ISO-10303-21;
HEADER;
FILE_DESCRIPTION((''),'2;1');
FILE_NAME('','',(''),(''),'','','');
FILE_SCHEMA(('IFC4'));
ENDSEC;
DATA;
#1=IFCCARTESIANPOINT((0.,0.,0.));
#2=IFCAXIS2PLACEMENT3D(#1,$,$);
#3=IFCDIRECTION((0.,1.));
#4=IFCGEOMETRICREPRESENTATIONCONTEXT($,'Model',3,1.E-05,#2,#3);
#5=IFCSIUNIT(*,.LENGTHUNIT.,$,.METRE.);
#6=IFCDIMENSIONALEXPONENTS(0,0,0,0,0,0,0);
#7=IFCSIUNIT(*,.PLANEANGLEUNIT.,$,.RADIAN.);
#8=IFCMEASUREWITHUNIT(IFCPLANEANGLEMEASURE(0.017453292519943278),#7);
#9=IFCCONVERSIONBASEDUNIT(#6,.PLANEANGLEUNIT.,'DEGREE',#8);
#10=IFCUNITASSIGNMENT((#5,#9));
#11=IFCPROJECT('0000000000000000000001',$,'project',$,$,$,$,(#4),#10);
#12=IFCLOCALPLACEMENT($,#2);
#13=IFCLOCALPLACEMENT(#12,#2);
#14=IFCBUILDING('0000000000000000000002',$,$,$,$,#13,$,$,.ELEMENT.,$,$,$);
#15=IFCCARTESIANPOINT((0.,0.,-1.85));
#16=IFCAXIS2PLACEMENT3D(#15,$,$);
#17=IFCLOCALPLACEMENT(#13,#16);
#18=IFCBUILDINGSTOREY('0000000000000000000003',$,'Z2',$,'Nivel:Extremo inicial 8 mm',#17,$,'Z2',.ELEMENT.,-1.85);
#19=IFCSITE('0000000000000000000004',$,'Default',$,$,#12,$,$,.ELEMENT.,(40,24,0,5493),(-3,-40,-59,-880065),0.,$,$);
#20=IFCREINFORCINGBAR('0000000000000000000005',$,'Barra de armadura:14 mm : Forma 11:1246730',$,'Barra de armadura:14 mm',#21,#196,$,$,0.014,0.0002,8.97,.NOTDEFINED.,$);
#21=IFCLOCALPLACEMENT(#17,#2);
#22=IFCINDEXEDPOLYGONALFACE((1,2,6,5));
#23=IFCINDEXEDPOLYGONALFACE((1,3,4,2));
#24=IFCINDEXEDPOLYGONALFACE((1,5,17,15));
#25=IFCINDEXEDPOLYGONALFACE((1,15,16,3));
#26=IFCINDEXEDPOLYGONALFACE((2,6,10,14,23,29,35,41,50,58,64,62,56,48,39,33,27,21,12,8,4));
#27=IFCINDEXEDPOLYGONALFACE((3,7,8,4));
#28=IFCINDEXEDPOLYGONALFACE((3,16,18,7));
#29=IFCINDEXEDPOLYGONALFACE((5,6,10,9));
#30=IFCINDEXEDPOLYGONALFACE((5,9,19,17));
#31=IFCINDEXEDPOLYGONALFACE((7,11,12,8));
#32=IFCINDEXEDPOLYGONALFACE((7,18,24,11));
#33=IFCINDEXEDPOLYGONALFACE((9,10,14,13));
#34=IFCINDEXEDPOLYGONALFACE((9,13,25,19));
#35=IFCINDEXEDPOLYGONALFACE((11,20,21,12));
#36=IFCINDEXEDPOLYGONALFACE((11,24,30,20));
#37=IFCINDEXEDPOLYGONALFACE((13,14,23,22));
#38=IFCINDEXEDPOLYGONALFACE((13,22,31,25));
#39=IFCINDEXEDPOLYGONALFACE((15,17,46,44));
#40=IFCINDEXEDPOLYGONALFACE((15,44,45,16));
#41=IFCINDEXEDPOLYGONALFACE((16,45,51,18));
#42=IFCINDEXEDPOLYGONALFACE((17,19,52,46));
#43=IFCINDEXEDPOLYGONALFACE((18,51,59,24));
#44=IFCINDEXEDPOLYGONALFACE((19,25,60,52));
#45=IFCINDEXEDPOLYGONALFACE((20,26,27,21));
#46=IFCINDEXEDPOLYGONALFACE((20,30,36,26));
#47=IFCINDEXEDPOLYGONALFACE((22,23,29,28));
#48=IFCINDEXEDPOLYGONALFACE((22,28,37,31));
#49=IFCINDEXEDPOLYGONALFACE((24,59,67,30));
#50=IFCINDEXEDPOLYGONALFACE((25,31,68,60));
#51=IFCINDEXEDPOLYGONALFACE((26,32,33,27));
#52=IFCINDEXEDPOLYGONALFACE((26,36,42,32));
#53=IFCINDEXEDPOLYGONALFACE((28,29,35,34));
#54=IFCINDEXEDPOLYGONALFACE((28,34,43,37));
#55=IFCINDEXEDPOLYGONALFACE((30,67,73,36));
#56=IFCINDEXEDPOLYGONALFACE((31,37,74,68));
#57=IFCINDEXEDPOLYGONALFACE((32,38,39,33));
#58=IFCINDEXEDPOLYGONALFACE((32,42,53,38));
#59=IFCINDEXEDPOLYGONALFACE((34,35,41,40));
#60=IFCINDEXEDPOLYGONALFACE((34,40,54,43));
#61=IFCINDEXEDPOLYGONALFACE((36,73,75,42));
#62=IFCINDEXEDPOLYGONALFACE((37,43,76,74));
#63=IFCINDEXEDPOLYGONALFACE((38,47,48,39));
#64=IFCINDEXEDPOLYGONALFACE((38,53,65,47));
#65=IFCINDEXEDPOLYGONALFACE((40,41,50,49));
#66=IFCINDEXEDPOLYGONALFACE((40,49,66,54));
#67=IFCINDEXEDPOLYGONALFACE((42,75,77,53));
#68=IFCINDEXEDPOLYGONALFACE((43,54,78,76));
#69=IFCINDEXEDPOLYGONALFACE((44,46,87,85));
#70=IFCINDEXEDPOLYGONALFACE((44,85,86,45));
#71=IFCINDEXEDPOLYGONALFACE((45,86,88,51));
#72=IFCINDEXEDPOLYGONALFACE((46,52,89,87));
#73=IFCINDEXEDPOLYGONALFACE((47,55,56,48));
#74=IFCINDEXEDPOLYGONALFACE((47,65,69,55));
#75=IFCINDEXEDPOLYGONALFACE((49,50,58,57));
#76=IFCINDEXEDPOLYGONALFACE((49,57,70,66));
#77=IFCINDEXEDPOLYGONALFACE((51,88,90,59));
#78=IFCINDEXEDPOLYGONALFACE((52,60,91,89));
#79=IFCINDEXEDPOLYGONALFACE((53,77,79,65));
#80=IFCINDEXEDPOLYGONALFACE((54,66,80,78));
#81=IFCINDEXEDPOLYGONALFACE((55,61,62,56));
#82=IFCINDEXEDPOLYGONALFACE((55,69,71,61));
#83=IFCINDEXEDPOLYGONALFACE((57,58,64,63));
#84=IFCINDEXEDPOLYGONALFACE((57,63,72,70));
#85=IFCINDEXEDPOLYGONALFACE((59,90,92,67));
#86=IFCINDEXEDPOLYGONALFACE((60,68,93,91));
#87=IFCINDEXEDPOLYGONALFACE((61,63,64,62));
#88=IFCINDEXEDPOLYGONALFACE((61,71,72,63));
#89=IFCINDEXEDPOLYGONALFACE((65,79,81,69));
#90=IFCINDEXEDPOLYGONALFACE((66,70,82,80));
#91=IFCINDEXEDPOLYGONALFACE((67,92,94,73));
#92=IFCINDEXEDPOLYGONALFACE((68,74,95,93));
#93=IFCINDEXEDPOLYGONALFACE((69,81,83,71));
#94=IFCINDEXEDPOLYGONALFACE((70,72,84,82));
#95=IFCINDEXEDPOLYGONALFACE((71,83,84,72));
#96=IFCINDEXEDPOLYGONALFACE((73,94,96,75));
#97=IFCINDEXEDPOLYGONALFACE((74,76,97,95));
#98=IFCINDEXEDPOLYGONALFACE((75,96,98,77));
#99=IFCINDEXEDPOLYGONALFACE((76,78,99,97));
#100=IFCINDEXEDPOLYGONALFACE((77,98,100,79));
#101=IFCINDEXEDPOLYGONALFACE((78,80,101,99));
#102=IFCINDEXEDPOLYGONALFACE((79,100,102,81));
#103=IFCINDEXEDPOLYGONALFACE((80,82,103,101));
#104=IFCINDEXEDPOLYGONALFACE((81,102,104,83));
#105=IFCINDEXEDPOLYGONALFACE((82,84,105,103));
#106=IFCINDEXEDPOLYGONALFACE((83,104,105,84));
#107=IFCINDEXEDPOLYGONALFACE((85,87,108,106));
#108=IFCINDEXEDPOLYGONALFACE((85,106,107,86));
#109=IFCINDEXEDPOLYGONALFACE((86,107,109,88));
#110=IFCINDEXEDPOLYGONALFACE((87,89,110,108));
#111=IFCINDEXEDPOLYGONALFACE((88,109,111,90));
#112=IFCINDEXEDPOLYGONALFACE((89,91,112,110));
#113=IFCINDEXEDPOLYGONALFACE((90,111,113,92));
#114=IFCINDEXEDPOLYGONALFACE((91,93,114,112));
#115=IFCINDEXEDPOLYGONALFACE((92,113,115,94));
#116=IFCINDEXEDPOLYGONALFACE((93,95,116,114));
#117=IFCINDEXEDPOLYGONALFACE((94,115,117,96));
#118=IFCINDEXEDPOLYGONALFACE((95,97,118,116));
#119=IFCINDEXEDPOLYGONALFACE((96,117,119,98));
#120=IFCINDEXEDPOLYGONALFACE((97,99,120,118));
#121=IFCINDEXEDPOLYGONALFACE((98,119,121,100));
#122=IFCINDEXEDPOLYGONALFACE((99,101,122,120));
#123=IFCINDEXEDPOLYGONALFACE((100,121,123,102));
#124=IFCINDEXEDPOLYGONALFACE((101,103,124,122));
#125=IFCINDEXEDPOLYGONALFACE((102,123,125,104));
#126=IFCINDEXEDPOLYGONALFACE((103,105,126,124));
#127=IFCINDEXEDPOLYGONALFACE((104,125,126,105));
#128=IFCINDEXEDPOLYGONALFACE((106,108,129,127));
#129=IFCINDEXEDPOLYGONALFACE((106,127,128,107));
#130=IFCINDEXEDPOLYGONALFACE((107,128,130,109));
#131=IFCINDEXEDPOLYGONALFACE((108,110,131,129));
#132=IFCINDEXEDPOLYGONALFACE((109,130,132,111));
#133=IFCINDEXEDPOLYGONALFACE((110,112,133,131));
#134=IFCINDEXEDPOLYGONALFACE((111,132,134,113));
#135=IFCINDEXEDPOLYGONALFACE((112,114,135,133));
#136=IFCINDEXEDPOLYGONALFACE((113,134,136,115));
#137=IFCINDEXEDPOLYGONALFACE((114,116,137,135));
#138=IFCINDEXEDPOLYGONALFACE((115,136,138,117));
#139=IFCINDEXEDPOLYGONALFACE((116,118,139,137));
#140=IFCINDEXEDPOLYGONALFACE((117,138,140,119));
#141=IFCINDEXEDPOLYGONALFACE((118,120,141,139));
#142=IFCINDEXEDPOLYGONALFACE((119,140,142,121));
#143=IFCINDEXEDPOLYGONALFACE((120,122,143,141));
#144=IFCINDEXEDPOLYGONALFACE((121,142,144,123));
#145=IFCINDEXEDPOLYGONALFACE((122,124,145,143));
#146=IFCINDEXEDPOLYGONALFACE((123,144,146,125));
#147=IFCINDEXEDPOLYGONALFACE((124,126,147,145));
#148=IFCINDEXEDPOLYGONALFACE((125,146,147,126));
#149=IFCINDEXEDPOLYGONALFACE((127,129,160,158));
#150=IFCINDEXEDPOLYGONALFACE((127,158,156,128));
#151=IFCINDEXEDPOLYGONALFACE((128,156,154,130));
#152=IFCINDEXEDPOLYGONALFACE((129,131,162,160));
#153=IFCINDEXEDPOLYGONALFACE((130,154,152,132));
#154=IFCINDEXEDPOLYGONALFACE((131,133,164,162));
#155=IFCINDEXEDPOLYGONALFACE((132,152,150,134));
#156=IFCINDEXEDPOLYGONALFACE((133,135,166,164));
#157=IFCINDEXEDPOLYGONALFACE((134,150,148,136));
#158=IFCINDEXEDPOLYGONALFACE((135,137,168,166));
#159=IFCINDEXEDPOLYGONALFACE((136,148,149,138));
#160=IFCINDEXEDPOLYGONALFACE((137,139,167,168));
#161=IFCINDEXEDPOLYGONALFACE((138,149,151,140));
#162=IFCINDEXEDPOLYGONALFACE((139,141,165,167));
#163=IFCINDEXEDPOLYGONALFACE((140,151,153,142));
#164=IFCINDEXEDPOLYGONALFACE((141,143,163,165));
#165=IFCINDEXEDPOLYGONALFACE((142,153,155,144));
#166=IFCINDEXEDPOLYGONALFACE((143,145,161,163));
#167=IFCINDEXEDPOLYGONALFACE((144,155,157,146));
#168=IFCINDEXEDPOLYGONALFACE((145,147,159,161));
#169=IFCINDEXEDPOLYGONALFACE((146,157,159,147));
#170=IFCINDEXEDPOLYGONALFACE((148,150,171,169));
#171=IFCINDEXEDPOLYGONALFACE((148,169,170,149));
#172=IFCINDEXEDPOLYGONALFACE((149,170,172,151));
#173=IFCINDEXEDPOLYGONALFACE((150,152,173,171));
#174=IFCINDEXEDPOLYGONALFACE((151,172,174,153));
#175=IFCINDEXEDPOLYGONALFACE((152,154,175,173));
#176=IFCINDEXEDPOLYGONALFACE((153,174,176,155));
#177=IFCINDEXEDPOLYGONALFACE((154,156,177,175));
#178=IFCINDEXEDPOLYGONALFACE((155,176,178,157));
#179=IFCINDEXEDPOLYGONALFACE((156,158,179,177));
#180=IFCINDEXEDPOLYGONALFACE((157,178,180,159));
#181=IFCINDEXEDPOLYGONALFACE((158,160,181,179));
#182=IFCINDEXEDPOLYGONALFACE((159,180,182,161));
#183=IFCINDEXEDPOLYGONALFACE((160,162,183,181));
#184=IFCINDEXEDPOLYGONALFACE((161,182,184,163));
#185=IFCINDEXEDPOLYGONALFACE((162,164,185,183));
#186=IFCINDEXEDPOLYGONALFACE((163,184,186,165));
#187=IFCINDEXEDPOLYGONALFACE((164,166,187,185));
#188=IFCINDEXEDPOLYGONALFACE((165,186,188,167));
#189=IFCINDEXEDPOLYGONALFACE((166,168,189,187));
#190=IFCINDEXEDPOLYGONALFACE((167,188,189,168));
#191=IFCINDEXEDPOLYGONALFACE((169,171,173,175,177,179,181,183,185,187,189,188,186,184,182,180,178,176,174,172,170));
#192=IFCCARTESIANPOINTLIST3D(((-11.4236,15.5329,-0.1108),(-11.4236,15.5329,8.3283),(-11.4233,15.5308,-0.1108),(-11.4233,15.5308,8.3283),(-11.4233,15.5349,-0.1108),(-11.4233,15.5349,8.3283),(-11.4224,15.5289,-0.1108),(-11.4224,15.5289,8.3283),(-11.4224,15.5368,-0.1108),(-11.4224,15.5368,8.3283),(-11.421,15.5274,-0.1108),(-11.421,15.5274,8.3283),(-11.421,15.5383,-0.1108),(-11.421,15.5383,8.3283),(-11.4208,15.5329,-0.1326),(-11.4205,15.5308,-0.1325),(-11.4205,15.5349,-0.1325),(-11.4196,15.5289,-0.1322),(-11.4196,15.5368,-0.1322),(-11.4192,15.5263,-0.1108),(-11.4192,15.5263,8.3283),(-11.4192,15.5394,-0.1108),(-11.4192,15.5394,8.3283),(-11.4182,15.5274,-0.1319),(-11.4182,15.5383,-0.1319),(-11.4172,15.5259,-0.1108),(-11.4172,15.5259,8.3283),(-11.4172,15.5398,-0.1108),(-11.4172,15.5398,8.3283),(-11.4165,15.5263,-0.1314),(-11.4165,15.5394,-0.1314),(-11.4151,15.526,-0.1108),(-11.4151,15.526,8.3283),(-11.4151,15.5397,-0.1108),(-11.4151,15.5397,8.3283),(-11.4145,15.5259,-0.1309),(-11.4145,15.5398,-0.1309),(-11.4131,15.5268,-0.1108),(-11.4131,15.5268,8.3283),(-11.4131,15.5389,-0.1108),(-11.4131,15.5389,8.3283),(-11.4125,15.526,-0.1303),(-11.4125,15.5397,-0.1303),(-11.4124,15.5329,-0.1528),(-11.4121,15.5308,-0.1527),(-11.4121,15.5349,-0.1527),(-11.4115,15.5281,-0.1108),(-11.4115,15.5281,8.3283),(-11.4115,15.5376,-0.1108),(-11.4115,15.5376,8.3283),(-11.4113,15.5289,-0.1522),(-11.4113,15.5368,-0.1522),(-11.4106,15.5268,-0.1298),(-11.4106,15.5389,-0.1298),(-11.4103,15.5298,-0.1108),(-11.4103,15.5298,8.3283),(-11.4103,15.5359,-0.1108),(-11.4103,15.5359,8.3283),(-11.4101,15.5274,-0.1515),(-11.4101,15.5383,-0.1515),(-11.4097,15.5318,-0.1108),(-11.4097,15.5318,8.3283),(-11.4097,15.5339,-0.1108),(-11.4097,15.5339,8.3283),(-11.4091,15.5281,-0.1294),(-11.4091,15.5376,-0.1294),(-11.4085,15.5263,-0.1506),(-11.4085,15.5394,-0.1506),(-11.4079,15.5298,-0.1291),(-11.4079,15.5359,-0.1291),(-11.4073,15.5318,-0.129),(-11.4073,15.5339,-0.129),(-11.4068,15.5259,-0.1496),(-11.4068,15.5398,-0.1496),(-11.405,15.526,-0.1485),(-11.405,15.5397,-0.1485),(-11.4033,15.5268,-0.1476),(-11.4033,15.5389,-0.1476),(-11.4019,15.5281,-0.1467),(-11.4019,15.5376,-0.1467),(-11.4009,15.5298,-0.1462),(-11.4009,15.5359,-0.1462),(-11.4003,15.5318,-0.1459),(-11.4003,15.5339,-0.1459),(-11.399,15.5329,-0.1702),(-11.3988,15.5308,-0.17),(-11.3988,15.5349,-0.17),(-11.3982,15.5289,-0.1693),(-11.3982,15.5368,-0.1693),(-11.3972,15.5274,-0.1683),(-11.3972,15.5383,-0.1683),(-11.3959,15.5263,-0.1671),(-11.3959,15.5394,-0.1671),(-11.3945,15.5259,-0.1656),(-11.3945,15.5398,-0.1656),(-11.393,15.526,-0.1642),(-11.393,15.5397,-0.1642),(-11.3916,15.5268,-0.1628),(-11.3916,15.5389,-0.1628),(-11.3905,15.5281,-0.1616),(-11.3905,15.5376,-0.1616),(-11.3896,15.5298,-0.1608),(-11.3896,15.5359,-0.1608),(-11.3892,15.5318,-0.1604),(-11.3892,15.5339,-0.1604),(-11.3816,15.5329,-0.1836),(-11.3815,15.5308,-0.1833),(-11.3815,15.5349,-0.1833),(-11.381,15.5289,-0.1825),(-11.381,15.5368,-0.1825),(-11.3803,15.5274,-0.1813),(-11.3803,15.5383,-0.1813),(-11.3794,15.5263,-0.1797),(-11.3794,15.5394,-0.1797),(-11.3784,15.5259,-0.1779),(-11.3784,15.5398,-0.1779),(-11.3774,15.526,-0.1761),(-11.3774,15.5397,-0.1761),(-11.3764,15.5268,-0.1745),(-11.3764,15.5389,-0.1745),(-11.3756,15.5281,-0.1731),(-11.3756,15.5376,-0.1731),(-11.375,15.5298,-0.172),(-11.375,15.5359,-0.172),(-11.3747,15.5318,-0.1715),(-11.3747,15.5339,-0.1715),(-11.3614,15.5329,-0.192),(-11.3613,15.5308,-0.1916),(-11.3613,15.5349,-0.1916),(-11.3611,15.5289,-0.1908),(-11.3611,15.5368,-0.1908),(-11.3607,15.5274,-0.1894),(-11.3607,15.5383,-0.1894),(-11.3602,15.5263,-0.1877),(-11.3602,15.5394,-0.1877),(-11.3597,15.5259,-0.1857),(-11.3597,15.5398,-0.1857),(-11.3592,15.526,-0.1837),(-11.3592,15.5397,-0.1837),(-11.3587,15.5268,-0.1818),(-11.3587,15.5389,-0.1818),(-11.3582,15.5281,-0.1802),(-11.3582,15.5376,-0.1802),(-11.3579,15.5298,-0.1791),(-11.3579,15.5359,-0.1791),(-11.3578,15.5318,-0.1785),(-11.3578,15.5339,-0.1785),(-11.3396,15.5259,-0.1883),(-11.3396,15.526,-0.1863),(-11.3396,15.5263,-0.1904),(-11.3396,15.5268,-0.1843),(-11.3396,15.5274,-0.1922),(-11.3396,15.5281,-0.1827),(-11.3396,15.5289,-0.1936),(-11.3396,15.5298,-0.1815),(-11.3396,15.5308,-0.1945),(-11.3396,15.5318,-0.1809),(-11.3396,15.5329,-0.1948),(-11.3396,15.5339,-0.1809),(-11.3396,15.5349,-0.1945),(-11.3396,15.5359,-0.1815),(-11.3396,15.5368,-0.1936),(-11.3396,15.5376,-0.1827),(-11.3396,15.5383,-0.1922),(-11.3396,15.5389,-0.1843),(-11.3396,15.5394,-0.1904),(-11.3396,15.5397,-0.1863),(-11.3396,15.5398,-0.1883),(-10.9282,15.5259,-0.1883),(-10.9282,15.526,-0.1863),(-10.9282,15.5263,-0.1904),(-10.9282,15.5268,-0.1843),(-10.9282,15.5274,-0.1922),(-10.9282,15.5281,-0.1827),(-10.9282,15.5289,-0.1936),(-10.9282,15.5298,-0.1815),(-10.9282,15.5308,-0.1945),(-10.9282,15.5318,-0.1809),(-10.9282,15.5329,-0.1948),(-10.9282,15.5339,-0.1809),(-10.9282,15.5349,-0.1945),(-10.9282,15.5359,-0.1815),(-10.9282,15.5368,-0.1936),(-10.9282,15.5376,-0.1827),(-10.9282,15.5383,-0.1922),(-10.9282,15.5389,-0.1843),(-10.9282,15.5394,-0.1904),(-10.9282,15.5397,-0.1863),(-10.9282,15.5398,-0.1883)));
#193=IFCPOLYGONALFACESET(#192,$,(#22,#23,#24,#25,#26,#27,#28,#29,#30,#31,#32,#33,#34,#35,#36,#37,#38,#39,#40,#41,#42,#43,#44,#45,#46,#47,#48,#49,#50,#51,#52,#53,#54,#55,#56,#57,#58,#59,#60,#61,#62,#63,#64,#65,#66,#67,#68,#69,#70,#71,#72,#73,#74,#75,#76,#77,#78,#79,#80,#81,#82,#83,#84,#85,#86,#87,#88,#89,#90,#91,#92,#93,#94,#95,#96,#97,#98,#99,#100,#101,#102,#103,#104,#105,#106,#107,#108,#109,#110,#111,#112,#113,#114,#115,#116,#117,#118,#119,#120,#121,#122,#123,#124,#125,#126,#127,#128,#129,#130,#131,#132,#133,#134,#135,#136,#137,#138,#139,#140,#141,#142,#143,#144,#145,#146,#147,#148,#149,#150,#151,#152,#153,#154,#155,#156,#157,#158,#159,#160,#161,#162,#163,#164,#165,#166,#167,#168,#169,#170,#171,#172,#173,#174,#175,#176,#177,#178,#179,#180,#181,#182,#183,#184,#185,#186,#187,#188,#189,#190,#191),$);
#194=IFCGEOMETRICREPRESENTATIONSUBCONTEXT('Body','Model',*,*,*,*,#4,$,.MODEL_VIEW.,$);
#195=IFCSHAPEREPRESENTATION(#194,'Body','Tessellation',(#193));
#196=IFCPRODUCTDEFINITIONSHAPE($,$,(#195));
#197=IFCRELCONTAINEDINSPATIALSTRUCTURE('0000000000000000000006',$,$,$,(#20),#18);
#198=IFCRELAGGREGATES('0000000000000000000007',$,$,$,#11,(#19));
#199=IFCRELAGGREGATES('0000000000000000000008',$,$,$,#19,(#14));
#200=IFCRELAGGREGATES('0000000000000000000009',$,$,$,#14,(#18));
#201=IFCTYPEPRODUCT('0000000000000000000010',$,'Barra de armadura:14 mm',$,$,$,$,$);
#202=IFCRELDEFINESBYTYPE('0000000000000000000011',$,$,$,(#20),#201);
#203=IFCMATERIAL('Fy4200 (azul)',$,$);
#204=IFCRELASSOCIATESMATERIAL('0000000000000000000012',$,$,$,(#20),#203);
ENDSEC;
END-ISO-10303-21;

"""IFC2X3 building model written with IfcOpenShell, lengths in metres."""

from ifc_helpers import new_model, entity, si_unit, converted_unit, direction, frame, origin, place, context, subcontext, project, spatial, material, type_object, element, save


model = new_model("IFC2X3")

# Units and contexts
model_context = context("Model", 3, precision=1e-05, world=origin(), true_north=direction((0.0, 1.0)))
body_context = subcontext(model_context, "Body", "Model", "MODEL_VIEW")
ifc_project = project(units=[si_unit("LENGTHUNIT", "METRE"), converted_unit("PLANEANGLEUNIT", "DEGREE", entity("IfcPlaneAngleMeasure", 0.017453292519943278), si_unit("PLANEANGLEUNIT", "RADIAN"), dimensions=[0, 0, 0, 0, 0, 0, 0])], contexts=[model_context])

# Site, building, storey
site_placement = place(None, origin())
site = spatial("IfcSite", under=ifc_project, at=site_placement, Name="Default", CompositionType="ELEMENT", RefLatitude=(40, 24, 0, 5493), RefLongitude=(-3, -40, -59, -880065), RefElevation=0.0)
building_placement = place(site_placement, origin())
building = spatial("IfcBuilding", under=site, at=building_placement, CompositionType="ELEMENT")
storey_placement = place(building_placement, frame((0.0, 0.0, -1.85)))
storey = spatial("IfcBuildingStorey", under=building, at=storey_placement, Name="Z2", ObjectType="Nivel:Extremo inicial 8 mm", LongName="Z2", CompositionType="ELEMENT", Elevation=-1.85)

# Reinforcing bar
ifc_material_1 = material(Name="Fy4200 (azul)")
type_product_1 = type_object("IfcTypeProduct", Name="Barra de armadura:14 mm")
reinforcing_bar_1_placement = place(storey_placement, origin())
element("IfcReinforcingBar", 1, at=reinforcing_bar_1_placement, inside=storey, type_object=type_product_1, material=ifc_material_1, Name="Barra de armadura:14 mm : Forma 11:1246730", ObjectType="Barra de armadura:14 mm", BarLength=8.97, BarRole="NOTDEFINED", CrossSectionArea=0.0002, NominalDiameter=0.014, context=body_context, shape_type="AdvancedSweptSolid", body=[
    entity("IfcSweptDiskSolid", entity("IfcCompositeCurve", [entity("IfcCompositeCurveSegment", "CONTINUOUS", True, entity("IfcPolyline", [entity("IfcCartesianPoint", [-11.4166, 15.5329, 8.3283]), entity("IfcCartesianPoint", [-11.4166, 15.5329, -0.1108])])), entity("IfcCompositeCurveSegment", "CONTINUOUS", True, entity("IfcTrimmedCurve", entity("IfcCircle", entity("IfcAxis2Placement3D", entity("IfcCartesianPoint", [-11.3396, 15.5329, -0.1108]), entity("IfcDirection", [0.0, -1.0, 0.0]), entity("IfcDirection", [0.0, 0.0, -1.0])), 0.077), [entity("IfcParameterValue", 270.0)], [entity("IfcParameterValue", 360.0)], True, "PARAMETER")), entity("IfcCompositeCurveSegment", "CONTINUOUS", True, entity("IfcPolyline", [entity("IfcCartesianPoint", [-11.3396, 15.5329, -0.1878]), entity("IfcCartesianPoint", [-10.9282, 15.5329, -0.1878])]))], False), 0.007, None, 0.0, 92.0),
])

save(model, "model.ifc")
